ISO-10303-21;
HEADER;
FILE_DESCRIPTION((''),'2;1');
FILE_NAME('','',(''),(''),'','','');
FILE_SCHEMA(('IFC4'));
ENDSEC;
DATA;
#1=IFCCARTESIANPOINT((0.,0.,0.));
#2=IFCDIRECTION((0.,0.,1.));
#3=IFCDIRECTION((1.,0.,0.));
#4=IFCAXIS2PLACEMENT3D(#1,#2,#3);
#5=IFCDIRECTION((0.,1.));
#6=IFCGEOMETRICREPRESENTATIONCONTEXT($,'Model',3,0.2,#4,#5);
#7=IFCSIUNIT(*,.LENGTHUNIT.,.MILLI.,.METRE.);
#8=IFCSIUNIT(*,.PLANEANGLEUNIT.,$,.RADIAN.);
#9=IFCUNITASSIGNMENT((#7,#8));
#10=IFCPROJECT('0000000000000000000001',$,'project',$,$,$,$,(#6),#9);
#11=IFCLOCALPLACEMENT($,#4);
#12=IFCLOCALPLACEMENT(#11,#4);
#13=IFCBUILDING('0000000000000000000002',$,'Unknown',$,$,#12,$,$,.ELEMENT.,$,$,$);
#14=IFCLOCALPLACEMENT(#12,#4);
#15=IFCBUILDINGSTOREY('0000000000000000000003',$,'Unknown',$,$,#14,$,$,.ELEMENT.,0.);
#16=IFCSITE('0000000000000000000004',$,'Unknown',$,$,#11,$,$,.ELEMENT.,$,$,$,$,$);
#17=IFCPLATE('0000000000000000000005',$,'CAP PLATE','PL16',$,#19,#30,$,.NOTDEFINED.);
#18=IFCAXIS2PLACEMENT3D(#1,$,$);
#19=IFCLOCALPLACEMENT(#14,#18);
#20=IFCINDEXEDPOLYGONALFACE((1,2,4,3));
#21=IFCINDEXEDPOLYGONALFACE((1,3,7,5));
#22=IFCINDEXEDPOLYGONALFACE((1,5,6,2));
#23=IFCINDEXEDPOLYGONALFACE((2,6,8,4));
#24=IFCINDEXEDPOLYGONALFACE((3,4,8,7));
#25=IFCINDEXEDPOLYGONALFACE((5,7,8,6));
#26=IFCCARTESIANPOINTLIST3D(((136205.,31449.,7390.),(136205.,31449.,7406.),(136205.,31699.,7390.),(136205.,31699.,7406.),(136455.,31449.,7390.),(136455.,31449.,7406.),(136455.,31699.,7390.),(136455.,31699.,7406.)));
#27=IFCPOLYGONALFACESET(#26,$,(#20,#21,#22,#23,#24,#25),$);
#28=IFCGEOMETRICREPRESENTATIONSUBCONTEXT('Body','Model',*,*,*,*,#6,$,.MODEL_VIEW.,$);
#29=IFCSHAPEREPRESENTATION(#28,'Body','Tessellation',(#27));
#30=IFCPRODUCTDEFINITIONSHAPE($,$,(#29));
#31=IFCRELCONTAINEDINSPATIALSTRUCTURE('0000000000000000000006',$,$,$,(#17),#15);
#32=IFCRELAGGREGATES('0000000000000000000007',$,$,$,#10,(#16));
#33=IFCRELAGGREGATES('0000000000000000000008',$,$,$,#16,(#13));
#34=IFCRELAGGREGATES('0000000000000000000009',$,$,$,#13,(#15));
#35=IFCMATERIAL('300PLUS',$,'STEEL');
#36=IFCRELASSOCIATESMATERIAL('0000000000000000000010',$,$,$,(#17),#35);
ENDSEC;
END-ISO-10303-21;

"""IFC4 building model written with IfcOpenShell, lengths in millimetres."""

from ifc_helpers import new_model, si_unit, direction, frame, origin_with_axes, place, context, subcontext, project, spatial, line, indexed_curve, outline, extrude, material, element, save


model = new_model("IFC4")

# Units and contexts
model_context = context("Model", 3, precision=0.2, world=origin_with_axes(), true_north=direction((0.0, 1.0)))
body_context = subcontext(model_context, "Body", "Model", "MODEL_VIEW")
ifc_project = project(units=[si_unit("LENGTHUNIT", "METRE", prefix="MILLI"), si_unit("PLANEANGLEUNIT", "RADIAN")], contexts=[model_context])

# Site, building, storey
site_placement = place(None, origin_with_axes())
site = spatial("IfcSite", under=ifc_project, at=site_placement, Name="Unknown", CompositionType="ELEMENT")
building_placement = place(site_placement, origin_with_axes())
building = spatial("IfcBuilding", under=site, at=building_placement, Name="Unknown", CompositionType="ELEMENT")
storey_placement = place(building_placement, origin_with_axes())
storey = spatial("IfcBuildingStorey", under=building, at=storey_placement, Name="Unknown", CompositionType="ELEMENT", Elevation=0.0)

# Shared definitions
ifc_material_1 = material(Name="300PLUS", Category="STEEL")

# Plate
for number, where, z_axis, x_axis, name in (
    (1, (136205.0, 31449.0, 7398.0), (0.0, 0.0, 1.0), (1.0, 0.0, 0.0), "CAP PLATE"),
):
    element("IfcPlate", number, at=place(storey_placement, frame(where, z_axis=z_axis, x_axis=x_axis)), inside=storey, material=ifc_material_1, Name=name, Description="PL16", PredefinedType="NOTDEFINED", context=body_context, shape_type="SolidModel", body=[
        extrude(outline(indexed_curve([(0.0, 0.0), (250.0, 0.0), (250.0, 250.0), (0.0, 250.0)], segments=[line(1, 2, 3, 4, 1)])), frame((0.0, 0.0, 8.0), z_axis=(0.0, 0.0, 1.0), x_axis=(1.0, 0.0, 0.0)), (0.0, 0.0, -1.0), 16.0),
    ])

save(model, "model.ifc")
